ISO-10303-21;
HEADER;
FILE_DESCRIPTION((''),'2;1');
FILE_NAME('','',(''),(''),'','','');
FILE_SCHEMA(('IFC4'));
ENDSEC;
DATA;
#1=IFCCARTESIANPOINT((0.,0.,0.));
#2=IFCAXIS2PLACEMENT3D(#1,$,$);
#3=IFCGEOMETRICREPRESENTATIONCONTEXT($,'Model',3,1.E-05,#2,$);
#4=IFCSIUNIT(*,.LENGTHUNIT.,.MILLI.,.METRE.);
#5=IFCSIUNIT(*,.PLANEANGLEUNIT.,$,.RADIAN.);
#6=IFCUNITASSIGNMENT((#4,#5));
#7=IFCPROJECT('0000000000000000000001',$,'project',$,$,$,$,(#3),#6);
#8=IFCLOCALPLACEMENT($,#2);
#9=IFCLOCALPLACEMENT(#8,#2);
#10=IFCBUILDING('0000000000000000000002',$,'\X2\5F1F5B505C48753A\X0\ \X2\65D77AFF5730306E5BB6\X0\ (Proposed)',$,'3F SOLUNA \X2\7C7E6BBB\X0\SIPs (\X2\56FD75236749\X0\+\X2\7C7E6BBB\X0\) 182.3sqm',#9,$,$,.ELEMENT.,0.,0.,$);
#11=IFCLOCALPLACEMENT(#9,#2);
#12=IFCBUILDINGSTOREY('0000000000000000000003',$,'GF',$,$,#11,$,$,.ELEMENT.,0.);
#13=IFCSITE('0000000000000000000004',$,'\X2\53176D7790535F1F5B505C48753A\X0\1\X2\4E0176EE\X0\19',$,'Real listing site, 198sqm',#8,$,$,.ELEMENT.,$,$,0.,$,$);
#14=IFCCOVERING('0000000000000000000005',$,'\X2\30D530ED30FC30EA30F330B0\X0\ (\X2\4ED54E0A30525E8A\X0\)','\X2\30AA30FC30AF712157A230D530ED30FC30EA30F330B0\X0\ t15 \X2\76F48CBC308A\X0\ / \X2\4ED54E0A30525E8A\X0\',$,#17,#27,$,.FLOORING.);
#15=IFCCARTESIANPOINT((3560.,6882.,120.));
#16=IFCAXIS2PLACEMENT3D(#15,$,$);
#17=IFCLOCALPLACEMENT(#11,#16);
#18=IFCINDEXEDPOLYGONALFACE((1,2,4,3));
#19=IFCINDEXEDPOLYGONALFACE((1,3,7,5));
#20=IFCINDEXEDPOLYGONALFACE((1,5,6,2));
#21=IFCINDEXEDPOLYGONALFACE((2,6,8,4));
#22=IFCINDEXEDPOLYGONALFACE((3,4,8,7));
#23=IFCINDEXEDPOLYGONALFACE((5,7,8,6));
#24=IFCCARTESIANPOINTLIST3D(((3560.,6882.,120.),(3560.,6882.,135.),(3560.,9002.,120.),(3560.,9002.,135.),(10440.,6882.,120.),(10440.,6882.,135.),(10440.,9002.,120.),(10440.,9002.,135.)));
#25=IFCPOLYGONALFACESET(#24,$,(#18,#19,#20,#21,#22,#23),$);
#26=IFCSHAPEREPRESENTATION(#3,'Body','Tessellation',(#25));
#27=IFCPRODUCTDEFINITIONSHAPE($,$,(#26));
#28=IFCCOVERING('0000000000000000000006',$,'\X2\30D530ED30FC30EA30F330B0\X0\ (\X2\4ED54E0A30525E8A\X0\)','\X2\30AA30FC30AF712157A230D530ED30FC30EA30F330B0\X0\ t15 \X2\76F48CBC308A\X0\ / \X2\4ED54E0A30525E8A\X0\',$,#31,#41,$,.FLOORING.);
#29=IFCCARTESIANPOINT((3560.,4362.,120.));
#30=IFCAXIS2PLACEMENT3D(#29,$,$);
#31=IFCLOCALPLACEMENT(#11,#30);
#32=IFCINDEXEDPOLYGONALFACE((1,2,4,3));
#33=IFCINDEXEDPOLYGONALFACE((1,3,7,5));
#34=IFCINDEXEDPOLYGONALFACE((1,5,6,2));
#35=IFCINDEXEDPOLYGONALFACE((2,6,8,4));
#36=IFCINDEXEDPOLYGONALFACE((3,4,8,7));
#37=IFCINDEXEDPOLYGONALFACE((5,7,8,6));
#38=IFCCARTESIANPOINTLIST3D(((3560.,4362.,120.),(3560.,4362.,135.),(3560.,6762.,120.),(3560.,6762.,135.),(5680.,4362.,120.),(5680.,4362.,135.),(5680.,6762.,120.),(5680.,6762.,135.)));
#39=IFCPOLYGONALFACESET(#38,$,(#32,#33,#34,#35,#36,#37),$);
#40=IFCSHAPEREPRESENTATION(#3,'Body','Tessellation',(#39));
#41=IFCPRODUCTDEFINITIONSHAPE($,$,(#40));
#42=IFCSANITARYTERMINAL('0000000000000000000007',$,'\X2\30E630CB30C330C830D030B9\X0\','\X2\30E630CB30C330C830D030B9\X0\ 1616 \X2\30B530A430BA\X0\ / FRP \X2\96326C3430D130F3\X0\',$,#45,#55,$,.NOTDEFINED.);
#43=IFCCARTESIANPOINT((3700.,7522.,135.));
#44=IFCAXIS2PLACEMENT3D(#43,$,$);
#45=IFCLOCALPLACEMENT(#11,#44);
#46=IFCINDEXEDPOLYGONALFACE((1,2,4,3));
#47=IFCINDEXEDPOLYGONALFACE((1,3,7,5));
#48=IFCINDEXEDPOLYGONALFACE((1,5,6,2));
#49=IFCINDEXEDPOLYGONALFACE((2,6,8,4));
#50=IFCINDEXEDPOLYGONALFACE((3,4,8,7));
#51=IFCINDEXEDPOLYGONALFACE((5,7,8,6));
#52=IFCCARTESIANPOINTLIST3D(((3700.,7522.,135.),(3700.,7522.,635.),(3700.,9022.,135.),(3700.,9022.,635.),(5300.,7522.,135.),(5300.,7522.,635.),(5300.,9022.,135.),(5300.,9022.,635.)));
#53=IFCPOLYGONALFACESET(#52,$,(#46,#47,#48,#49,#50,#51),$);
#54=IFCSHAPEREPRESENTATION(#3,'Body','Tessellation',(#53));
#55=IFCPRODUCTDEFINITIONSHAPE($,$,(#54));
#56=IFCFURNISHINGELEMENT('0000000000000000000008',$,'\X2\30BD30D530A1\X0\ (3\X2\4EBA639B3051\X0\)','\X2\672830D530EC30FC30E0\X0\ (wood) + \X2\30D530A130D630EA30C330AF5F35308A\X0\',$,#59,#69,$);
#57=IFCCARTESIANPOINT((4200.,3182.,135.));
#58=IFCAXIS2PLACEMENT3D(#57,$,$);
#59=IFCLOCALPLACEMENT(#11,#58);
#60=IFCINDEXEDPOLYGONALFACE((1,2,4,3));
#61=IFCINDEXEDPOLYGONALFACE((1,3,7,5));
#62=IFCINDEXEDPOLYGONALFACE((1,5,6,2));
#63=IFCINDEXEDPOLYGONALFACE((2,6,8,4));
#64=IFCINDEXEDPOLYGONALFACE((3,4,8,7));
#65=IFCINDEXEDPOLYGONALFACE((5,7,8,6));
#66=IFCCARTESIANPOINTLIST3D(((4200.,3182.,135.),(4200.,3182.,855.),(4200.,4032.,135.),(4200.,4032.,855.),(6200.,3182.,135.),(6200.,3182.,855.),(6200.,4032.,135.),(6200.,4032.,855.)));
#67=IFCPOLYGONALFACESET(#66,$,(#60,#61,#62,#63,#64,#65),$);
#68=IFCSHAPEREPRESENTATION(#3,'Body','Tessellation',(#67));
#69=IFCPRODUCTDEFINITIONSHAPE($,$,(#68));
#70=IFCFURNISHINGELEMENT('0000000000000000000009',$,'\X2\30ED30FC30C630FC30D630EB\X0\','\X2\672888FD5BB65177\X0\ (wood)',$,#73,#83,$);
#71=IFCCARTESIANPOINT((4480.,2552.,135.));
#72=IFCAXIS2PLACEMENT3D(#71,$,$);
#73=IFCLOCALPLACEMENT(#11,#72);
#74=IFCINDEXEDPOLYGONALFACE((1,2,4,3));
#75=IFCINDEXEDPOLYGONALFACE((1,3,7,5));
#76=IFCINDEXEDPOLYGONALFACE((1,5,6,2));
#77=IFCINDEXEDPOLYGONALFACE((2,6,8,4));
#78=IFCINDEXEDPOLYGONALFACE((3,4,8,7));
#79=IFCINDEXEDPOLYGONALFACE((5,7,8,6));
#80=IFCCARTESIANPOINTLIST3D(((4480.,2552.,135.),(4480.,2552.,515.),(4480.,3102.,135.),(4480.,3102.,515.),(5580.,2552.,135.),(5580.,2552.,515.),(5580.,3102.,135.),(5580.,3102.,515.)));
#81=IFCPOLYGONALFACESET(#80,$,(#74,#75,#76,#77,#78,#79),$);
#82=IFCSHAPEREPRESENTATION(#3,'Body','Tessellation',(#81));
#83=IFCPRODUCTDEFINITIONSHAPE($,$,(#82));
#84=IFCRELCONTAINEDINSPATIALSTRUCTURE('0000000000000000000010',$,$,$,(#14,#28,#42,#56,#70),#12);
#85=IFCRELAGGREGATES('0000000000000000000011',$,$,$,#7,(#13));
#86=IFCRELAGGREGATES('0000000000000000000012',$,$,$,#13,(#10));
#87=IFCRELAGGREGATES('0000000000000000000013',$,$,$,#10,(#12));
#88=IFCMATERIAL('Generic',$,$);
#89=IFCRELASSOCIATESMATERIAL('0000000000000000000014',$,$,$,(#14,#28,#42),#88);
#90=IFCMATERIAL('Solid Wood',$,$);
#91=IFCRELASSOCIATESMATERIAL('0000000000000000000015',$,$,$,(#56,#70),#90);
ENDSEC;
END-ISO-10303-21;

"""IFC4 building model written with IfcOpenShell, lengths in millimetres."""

from ifc_helpers import new_model, si_unit, frame, frame_2d, origin, place, context, project, spatial, rectangle, extrude, material, element, save


model = new_model("IFC4")

# Units and contexts
model_context = context("Model", 3, precision=1e-05, world=origin())
ifc_project = project(units=[si_unit("LENGTHUNIT", "METRE", prefix="MILLI"), si_unit("PLANEANGLEUNIT", "RADIAN")], contexts=[model_context])

# Site, building, storey
site_placement = place(None, origin())
site = spatial("IfcSite", under=ifc_project, at=site_placement, Name="北海道弟子屈町1丁目19", ObjectType="Real listing site, 198sqm", CompositionType="ELEMENT", RefElevation=0.0)
building_placement = place(site_placement, origin())
building = spatial("IfcBuilding", under=site, at=building_placement, Name="弟子屈町 旗竿地の家 (Proposed)", ObjectType="3F SOLUNA 籾殻SIPs (国産杉+籾殻) 182.3sqm", CompositionType="ELEMENT", ElevationOfRefHeight=0.0, ElevationOfTerrain=0.0)
storey_placement = place(building_placement, origin())
storey = spatial("IfcBuildingStorey", under=building, at=storey_placement, Name="GF", CompositionType="ELEMENT", Elevation=0.0)

# Shared definitions
ifc_material_1 = material(Name="Solid Wood")

# Coverings
ifc_material_2 = material(Name="Generic")
covering_1_placement = place(storey_placement, frame((3560.0, 6882.0, 120.0)))
element("IfcCovering", 1, at=covering_1_placement, inside=storey, material=ifc_material_2, Name="フローリング (仕上げ床)", Description="オーク無垢フローリング t15 直貼り / 仕上げ床", PredefinedType="FLOORING", context=model_context, shape_type="SweptSolid", body=[
    extrude(rectangle(XDim=6880.0, YDim=2120.0, at=frame_2d((3440.0, 1060.0))), frame((3560.0, 6882.0, 120.0)), (0.0, 0.0, 1.0), 15.0),
])
covering_2_placement = place(storey_placement, frame((3560.0, 4362.0, 120.0)))
element("IfcCovering", 2, at=covering_2_placement, inside=storey, material=ifc_material_2, Name="フローリング (仕上げ床)", Description="オーク無垢フローリング t15 直貼り / 仕上げ床", PredefinedType="FLOORING", context=model_context, shape_type="SweptSolid", body=[
    extrude(rectangle(XDim=2120.0, YDim=2400.0, at=frame_2d((1060.0, 1200.0))), frame((3560.0, 4362.0, 120.0)), (0.0, 0.0, 1.0), 15.0),
])

# Sanitary terminal
sanitary_terminal_placement = place(storey_placement, frame((3700.0, 7522.0, 135.0)))
element("IfcSanitaryTerminal", 3, at=sanitary_terminal_placement, inside=storey, material=ifc_material_2, Name="ユニットバス", Description="ユニットバス 1616 サイズ / FRP 防水パン", PredefinedType="NOTDEFINED", context=model_context, shape_type="SweptSolid", body=[
    extrude(rectangle(XDim=1600.0, YDim=1500.0, at=frame_2d((800.0, 750.0))), frame((3700.0, 7522.0, 135.0)), (0.0, 0.0, 1.0), 500.0),
])

# Furnishing elements
furnishing_1_placement = place(storey_placement, frame((4200.0, 3182.0, 135.0)))
element("IfcFurnishingElement", 4, at=furnishing_1_placement, inside=storey, material=ifc_material_1, Name="ソファ (3人掛け)", Description="木フレーム (wood) + ファブリック張り", context=model_context, shape_type="SweptSolid", body=[
    extrude(rectangle(XDim=2000.0, YDim=850.0, at=frame_2d((1000.0, 425.0))), frame((4200.0, 3182.0, 135.0)), (0.0, 0.0, 1.0), 720.0),
])
furnishing_2_placement = place(storey_placement, frame((4480.0, 2552.0, 135.0)))
element("IfcFurnishingElement", 5, at=furnishing_2_placement, inside=storey, material=ifc_material_1, Name="ローテーブル", Description="木製家具 (wood)", context=model_context, shape_type="SweptSolid", body=[
    extrude(rectangle(XDim=1100.0, YDim=550.0, at=frame_2d((550.0, 275.0))), frame((4480.0, 2552.0, 135.0)), (0.0, 0.0, 1.0), 380.0),
])

save(model, "model.ifc")
